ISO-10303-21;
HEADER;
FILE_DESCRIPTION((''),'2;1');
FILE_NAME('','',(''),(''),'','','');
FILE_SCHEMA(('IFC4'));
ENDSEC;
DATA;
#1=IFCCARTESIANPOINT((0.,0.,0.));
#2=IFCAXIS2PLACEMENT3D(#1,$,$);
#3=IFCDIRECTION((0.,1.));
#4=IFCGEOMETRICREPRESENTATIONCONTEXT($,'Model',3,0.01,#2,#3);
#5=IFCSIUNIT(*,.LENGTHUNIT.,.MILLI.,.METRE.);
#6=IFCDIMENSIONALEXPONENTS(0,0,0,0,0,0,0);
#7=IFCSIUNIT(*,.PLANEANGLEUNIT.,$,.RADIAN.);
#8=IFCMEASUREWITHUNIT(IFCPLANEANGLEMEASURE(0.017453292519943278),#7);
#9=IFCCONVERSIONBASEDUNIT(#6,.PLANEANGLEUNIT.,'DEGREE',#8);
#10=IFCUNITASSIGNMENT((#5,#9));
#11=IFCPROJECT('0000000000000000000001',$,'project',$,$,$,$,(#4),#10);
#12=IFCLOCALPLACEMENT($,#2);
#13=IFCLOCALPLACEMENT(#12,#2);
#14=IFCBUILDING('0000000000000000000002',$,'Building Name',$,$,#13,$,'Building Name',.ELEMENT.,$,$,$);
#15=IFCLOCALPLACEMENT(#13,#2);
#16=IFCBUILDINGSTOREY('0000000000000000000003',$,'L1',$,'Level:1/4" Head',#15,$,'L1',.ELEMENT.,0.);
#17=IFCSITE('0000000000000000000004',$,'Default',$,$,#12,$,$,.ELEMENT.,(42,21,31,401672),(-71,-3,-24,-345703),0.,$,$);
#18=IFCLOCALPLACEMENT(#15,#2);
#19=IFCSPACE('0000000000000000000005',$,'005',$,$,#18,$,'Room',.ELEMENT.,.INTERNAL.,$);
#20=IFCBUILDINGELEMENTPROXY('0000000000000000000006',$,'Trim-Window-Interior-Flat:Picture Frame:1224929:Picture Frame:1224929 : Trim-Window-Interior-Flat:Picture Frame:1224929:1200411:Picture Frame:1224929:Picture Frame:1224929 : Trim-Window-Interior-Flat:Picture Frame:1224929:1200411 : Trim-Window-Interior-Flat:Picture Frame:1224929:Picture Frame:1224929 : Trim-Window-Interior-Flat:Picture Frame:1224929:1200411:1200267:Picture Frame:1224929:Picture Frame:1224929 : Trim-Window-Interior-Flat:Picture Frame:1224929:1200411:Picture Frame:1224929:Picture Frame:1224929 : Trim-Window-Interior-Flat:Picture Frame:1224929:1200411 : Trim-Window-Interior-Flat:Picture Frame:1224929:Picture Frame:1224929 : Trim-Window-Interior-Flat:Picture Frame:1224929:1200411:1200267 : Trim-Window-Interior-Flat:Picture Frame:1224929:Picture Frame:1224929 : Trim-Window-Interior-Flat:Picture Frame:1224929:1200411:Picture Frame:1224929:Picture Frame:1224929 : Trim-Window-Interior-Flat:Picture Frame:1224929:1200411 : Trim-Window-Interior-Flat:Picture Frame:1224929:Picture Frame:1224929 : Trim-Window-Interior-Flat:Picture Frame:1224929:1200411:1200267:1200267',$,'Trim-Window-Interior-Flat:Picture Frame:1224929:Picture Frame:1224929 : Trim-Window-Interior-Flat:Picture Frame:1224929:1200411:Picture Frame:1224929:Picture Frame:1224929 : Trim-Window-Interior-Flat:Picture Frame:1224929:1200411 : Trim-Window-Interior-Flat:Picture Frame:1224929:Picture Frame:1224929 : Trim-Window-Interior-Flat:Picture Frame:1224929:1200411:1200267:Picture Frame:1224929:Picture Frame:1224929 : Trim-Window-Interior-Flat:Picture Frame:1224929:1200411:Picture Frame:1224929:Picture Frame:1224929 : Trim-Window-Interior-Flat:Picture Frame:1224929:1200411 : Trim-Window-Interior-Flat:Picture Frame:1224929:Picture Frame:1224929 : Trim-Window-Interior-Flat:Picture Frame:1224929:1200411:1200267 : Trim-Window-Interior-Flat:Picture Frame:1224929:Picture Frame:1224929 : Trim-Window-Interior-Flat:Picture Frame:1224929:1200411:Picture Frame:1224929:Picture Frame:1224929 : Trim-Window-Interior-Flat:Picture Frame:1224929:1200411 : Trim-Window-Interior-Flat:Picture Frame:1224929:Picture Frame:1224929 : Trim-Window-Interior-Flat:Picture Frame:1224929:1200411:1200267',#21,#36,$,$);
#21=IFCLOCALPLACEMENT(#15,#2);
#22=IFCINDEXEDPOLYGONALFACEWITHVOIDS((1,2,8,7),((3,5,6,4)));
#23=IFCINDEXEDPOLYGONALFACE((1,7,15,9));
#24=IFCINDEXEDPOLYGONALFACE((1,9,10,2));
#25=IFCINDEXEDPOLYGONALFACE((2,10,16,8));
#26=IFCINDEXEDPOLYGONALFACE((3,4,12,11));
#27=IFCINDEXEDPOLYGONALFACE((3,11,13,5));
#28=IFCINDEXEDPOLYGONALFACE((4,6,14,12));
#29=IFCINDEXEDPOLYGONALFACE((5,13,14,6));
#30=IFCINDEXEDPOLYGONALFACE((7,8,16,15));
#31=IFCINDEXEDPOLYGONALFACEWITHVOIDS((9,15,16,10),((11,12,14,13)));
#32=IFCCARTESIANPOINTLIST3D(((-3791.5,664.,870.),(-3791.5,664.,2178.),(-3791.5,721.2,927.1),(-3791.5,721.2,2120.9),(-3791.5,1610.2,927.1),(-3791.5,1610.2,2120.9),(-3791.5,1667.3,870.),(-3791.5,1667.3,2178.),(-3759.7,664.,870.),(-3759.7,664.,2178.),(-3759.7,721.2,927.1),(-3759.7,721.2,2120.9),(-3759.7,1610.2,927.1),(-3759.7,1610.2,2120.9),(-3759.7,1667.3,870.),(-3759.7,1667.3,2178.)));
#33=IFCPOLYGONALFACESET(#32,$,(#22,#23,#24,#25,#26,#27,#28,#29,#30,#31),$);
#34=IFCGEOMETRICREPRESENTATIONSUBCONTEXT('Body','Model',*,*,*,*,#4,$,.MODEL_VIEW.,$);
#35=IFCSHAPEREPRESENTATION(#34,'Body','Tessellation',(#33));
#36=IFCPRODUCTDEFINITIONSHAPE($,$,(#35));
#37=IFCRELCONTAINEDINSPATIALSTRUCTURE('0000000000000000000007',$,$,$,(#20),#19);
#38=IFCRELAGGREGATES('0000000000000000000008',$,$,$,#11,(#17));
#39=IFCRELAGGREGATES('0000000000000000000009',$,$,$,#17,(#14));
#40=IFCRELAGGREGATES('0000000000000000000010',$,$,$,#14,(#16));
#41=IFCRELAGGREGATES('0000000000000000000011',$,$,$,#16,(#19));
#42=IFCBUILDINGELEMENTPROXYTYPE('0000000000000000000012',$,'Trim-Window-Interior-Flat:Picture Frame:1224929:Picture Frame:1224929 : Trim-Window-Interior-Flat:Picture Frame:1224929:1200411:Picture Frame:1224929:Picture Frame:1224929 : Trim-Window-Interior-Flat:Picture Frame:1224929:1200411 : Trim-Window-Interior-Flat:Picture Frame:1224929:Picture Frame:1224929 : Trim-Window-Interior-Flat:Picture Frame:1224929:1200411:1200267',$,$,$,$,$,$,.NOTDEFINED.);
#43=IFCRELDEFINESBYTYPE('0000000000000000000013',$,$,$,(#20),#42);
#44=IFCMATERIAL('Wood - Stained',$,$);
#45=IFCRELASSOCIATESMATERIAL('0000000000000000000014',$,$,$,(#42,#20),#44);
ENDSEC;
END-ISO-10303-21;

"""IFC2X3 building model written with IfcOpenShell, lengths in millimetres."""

from ifc_helpers import new_model, entity, si_unit, converted_unit, direction, frame, origin, place, context, subcontext, project, spatial, polyline, outline, extrude, source, transform, mapped, material, type_object, type_shapes, element, save


model = new_model("IFC2X3")

# Units and contexts
model_context = context("Model", 3, precision=0.01, world=origin(), true_north=direction((0.0, 1.0)))
body_context = subcontext(model_context, "Body", "Model", "MODEL_VIEW")
ifc_project = project(units=[si_unit("LENGTHUNIT", "METRE", prefix="MILLI"), converted_unit("PLANEANGLEUNIT", "DEGREE", entity("IfcPlaneAngleMeasure", 0.017453292519943278), si_unit("PLANEANGLEUNIT", "RADIAN"), dimensions=[0, 0, 0, 0, 0, 0, 0])], contexts=[model_context])

# Site, building, storey
site_placement = place(None, origin())
site = spatial("IfcSite", under=ifc_project, at=site_placement, Name="Default", CompositionType="ELEMENT", RefLatitude=(42, 21, 31, 401672), RefLongitude=(-71, -3, -24, -345703), RefElevation=0.0)
building_placement = place(site_placement, origin())
building = spatial("IfcBuilding", under=site, at=building_placement, Name="Building Name", LongName="Building Name", CompositionType="ELEMENT")
storey_placement = place(building_placement, origin())
storey = spatial("IfcBuildingStorey", under=building, at=storey_placement, Name="L1", ObjectType="Level:1/4\" Head", LongName="L1", CompositionType="ELEMENT", Elevation=0.0)

# Shared definitions
space_placement = place(storey_placement, origin())
space = spatial("IfcSpace", under=storey, at=space_placement, Name="005", LongName="Room", CompositionType="ELEMENT", InteriorOrExteriorSpace="INTERNAL")

# Building element proxy
ifc_material_1 = material(Name="Wood - Stained")
building_element_proxy_type_1 = type_object("IfcBuildingElementProxyType", Name="Trim-Window-Interior-Flat:Picture Frame:1224929:Picture Frame:1224929 : Trim-Window-Interior-Flat:Picture Frame:1224929:1200411:Picture Frame:1224929:Picture Frame:1224929 : Trim-Window-Interior-Flat:Picture Frame:1224929:1200411 : Trim-Window-Interior-Flat:Picture Frame:1224929:Picture Frame:1224929 : Trim-Window-Interior-Flat:Picture Frame:1224929:1200411:1200267", PredefinedType="NOTDEFINED", material=ifc_material_1)
shared_shape_1 = source(origin(), body_context, "Body", "SweptSolid", [
    extrude(outline(polyline([(-654.0, -501.6), (654.0, -501.6), (654.0, 501.6), (-654.0, 501.6), (-654.0, -501.6)]), holes=[polyline([(596.9, 444.5), (596.9, -444.5), (-596.9, -444.5), (-596.9, 444.5), (596.9, 444.5)])]), frame((-3791.5, 1165.7, 1524.0), z_axis=(1.0, 0.0, 0.0), x_axis=(0.0, 0.0, 1.0)), (0.0, 0.0, 1.0), 31.7),
])
type_shapes(building_element_proxy_type_1, [shared_shape_1])
proxy_1_placement = place(space_placement, origin())
element("IfcBuildingElementProxy", 1, at=proxy_1_placement, inside=space, type_object=building_element_proxy_type_1, material=ifc_material_1, Name="Trim-Window-Interior-Flat:Picture Frame:1224929:Picture Frame:1224929 : Trim-Window-Interior-Flat:Picture Frame:1224929:1200411:Picture Frame:1224929:Picture Frame:1224929 : Trim-Window-Interior-Flat:Picture Frame:1224929:1200411 : Trim-Window-Interior-Flat:Picture Frame:1224929:Picture Frame:1224929 : Trim-Window-Interior-Flat:Picture Frame:1224929:1200411:1200267:Picture Frame:1224929:Picture Frame:1224929 : Trim-Window-Interior-Flat:Picture Frame:1224929:1200411:Picture Frame:1224929:Picture Frame:1224929 : Trim-Window-Interior-Flat:Picture Frame:1224929:1200411 : Trim-Window-Interior-Flat:Picture Frame:1224929:Picture Frame:1224929 : Trim-Window-Interior-Flat:Picture Frame:1224929:1200411:1200267 : Trim-Window-Interior-Flat:Picture Frame:1224929:Picture Frame:1224929 : Trim-Window-Interior-Flat:Picture Frame:1224929:1200411:Picture Frame:1224929:Picture Frame:1224929 : Trim-Window-Interior-Flat:Picture Frame:1224929:1200411 : Trim-Window-Interior-Flat:Picture Frame:1224929:Picture Frame:1224929 : Trim-Window-Interior-Flat:Picture Frame:1224929:1200411:1200267:1200267", ObjectType="Trim-Window-Interior-Flat:Picture Frame:1224929:Picture Frame:1224929 : Trim-Window-Interior-Flat:Picture Frame:1224929:1200411:Picture Frame:1224929:Picture Frame:1224929 : Trim-Window-Interior-Flat:Picture Frame:1224929:1200411 : Trim-Window-Interior-Flat:Picture Frame:1224929:Picture Frame:1224929 : Trim-Window-Interior-Flat:Picture Frame:1224929:1200411:1200267:Picture Frame:1224929:Picture Frame:1224929 : Trim-Window-Interior-Flat:Picture Frame:1224929:1200411:Picture Frame:1224929:Picture Frame:1224929 : Trim-Window-Interior-Flat:Picture Frame:1224929:1200411 : Trim-Window-Interior-Flat:Picture Frame:1224929:Picture Frame:1224929 : Trim-Window-Interior-Flat:Picture Frame:1224929:1200411:1200267 : Trim-Window-Interior-Flat:Picture Frame:1224929:Picture Frame:1224929 : Trim-Window-Interior-Flat:Picture Frame:1224929:1200411:Picture Frame:1224929:Picture Frame:1224929 : Trim-Window-Interior-Flat:Picture Frame:1224929:1200411 : Trim-Window-Interior-Flat:Picture Frame:1224929:Picture Frame:1224929 : Trim-Window-Interior-Flat:Picture Frame:1224929:1200411:1200267", context=body_context, shape_type="MappedRepresentation", body=[
    mapped(shared_shape_1, transform((0.0, 0.0, 0.0), scale=1.0)),
])

save(model, "model.ifc")
